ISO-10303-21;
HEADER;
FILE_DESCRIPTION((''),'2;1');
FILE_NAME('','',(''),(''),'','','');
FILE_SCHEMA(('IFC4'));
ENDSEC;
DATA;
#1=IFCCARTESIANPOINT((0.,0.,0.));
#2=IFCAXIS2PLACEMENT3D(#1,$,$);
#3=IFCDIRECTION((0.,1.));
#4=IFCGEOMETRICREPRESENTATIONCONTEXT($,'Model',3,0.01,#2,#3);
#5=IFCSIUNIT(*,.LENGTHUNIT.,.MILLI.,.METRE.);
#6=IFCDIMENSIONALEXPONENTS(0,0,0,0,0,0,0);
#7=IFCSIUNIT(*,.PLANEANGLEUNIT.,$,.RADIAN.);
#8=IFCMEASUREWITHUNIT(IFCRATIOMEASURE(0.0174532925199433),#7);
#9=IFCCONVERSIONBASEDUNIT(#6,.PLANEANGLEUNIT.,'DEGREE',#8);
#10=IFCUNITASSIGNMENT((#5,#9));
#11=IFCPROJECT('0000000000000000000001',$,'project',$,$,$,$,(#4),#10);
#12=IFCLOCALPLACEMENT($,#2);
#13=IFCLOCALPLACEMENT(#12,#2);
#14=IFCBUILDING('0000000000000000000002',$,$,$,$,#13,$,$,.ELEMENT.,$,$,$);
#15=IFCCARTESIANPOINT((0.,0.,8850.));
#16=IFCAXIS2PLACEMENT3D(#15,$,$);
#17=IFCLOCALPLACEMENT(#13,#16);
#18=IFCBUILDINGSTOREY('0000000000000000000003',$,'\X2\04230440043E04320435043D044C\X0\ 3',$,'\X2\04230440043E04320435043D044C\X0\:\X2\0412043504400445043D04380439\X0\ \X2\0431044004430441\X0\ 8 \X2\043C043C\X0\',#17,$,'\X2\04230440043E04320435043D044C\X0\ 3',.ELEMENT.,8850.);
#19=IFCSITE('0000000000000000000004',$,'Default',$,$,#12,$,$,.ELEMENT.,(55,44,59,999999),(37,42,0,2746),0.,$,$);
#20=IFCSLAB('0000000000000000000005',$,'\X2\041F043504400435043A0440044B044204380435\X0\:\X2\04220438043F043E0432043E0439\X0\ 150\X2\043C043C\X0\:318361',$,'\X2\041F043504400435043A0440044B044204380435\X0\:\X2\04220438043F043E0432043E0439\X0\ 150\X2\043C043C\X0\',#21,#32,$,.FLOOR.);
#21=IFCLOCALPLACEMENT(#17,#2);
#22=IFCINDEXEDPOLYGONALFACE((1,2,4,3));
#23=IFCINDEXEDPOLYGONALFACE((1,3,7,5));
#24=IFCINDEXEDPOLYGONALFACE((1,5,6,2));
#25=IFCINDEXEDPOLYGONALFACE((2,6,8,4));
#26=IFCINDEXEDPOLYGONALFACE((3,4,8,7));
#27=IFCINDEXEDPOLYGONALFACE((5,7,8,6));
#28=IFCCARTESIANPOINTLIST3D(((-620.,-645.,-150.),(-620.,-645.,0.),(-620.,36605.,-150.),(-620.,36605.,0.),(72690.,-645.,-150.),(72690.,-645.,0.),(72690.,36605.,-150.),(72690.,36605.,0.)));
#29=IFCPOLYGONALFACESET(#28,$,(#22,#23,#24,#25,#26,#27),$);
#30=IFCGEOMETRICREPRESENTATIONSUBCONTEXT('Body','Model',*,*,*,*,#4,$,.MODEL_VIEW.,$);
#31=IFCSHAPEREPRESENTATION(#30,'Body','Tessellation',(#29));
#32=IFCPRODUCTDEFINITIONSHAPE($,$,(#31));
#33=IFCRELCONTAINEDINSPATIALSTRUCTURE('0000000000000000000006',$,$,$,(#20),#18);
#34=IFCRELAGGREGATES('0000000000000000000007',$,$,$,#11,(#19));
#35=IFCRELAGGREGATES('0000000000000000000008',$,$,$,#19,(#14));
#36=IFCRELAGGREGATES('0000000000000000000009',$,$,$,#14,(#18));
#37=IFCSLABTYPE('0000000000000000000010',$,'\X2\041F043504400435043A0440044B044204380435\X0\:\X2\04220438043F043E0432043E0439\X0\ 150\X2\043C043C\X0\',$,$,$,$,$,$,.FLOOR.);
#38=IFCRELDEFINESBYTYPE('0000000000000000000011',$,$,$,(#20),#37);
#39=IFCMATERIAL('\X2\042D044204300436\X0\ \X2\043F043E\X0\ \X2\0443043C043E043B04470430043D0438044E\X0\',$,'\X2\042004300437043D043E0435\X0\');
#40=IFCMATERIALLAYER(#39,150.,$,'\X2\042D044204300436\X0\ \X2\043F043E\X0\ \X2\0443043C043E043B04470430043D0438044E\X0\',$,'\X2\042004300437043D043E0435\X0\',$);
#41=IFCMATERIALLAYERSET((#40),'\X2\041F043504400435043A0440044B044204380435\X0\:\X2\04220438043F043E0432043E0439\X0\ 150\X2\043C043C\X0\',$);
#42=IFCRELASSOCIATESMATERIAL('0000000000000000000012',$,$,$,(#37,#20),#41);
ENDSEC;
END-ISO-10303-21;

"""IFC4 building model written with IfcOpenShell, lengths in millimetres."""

from ifc_helpers import new_model, entity, si_unit, converted_unit, direction, frame, origin, origin_2d_with_axis, place, context, subcontext, project, spatial, rectangle, extrude, material, layer, layer_set, layer_usage, type_object, element, save


model = new_model("IFC4")

# Units and contexts
model_context = context("Model", 3, precision=0.01, world=origin(), true_north=direction((0.0, 1.0)))
body_context = subcontext(model_context, "Body", "Model", "MODEL_VIEW")
ifc_project = project(units=[si_unit("LENGTHUNIT", "METRE", prefix="MILLI"), converted_unit("PLANEANGLEUNIT", "DEGREE", entity("IfcRatioMeasure", 0.0174532925199433), si_unit("PLANEANGLEUNIT", "RADIAN"), dimensions=[0, 0, 0, 0, 0, 0, 0])], contexts=[model_context])

# Site, building, storey
site_placement = place(None, origin())
site = spatial("IfcSite", under=ifc_project, at=site_placement, Name="Default", CompositionType="ELEMENT", RefLatitude=(55, 44, 59, 999999), RefLongitude=(37, 42, 0, 2746), RefElevation=0.0)
building_placement = place(site_placement, origin())
building = spatial("IfcBuilding", under=site, at=building_placement, CompositionType="ELEMENT")
storey_placement = place(building_placement, frame((0.0, 0.0, 8850.0)))
storey = spatial("IfcBuildingStorey", under=building, at=storey_placement, Name="Уровень 3", ObjectType="Уровень:Верхний брус 8 мм", LongName="Уровень 3", CompositionType="ELEMENT", Elevation=8850.0)

# Slab
ifc_material = material(Name="Этаж по умолчанию", Category="Разное")
ifc_layer = layer(ifc_material, 150.0, Name="Этаж по умолчанию", Category="Разное")
ifc_layer_set = layer_set([ifc_layer], Name="Перекрытие:Типовой 150мм")
ifc_layer_usage = layer_usage(ifc_layer_set, "AXIS3", "POSITIVE", 0.0)
slab_type = type_object("IfcSlabType", Name="Перекрытие:Типовой 150мм", PredefinedType="FLOOR", material=ifc_layer_set)
slab_placement = place(storey_placement, origin())
element("IfcSlab", 1, at=slab_placement, inside=storey, type_object=slab_type, material=ifc_layer_usage, Name="Перекрытие:Типовой 150мм:318361", ObjectType="Перекрытие:Типовой 150мм", PredefinedType="FLOOR", context=body_context, shape_type="SweptSolid", body=[
    extrude(rectangle(XDim=37250.0, YDim=73310.0, at=origin_2d_with_axis()), frame((36035.0, 17980.0, 0.0), z_axis=(0.0, 0.0, -1.0), x_axis=(0.0, 1.0, 0.0)), (0.0, 0.0, 1.0), 150.0),
])

save(model, "model.ifc")
